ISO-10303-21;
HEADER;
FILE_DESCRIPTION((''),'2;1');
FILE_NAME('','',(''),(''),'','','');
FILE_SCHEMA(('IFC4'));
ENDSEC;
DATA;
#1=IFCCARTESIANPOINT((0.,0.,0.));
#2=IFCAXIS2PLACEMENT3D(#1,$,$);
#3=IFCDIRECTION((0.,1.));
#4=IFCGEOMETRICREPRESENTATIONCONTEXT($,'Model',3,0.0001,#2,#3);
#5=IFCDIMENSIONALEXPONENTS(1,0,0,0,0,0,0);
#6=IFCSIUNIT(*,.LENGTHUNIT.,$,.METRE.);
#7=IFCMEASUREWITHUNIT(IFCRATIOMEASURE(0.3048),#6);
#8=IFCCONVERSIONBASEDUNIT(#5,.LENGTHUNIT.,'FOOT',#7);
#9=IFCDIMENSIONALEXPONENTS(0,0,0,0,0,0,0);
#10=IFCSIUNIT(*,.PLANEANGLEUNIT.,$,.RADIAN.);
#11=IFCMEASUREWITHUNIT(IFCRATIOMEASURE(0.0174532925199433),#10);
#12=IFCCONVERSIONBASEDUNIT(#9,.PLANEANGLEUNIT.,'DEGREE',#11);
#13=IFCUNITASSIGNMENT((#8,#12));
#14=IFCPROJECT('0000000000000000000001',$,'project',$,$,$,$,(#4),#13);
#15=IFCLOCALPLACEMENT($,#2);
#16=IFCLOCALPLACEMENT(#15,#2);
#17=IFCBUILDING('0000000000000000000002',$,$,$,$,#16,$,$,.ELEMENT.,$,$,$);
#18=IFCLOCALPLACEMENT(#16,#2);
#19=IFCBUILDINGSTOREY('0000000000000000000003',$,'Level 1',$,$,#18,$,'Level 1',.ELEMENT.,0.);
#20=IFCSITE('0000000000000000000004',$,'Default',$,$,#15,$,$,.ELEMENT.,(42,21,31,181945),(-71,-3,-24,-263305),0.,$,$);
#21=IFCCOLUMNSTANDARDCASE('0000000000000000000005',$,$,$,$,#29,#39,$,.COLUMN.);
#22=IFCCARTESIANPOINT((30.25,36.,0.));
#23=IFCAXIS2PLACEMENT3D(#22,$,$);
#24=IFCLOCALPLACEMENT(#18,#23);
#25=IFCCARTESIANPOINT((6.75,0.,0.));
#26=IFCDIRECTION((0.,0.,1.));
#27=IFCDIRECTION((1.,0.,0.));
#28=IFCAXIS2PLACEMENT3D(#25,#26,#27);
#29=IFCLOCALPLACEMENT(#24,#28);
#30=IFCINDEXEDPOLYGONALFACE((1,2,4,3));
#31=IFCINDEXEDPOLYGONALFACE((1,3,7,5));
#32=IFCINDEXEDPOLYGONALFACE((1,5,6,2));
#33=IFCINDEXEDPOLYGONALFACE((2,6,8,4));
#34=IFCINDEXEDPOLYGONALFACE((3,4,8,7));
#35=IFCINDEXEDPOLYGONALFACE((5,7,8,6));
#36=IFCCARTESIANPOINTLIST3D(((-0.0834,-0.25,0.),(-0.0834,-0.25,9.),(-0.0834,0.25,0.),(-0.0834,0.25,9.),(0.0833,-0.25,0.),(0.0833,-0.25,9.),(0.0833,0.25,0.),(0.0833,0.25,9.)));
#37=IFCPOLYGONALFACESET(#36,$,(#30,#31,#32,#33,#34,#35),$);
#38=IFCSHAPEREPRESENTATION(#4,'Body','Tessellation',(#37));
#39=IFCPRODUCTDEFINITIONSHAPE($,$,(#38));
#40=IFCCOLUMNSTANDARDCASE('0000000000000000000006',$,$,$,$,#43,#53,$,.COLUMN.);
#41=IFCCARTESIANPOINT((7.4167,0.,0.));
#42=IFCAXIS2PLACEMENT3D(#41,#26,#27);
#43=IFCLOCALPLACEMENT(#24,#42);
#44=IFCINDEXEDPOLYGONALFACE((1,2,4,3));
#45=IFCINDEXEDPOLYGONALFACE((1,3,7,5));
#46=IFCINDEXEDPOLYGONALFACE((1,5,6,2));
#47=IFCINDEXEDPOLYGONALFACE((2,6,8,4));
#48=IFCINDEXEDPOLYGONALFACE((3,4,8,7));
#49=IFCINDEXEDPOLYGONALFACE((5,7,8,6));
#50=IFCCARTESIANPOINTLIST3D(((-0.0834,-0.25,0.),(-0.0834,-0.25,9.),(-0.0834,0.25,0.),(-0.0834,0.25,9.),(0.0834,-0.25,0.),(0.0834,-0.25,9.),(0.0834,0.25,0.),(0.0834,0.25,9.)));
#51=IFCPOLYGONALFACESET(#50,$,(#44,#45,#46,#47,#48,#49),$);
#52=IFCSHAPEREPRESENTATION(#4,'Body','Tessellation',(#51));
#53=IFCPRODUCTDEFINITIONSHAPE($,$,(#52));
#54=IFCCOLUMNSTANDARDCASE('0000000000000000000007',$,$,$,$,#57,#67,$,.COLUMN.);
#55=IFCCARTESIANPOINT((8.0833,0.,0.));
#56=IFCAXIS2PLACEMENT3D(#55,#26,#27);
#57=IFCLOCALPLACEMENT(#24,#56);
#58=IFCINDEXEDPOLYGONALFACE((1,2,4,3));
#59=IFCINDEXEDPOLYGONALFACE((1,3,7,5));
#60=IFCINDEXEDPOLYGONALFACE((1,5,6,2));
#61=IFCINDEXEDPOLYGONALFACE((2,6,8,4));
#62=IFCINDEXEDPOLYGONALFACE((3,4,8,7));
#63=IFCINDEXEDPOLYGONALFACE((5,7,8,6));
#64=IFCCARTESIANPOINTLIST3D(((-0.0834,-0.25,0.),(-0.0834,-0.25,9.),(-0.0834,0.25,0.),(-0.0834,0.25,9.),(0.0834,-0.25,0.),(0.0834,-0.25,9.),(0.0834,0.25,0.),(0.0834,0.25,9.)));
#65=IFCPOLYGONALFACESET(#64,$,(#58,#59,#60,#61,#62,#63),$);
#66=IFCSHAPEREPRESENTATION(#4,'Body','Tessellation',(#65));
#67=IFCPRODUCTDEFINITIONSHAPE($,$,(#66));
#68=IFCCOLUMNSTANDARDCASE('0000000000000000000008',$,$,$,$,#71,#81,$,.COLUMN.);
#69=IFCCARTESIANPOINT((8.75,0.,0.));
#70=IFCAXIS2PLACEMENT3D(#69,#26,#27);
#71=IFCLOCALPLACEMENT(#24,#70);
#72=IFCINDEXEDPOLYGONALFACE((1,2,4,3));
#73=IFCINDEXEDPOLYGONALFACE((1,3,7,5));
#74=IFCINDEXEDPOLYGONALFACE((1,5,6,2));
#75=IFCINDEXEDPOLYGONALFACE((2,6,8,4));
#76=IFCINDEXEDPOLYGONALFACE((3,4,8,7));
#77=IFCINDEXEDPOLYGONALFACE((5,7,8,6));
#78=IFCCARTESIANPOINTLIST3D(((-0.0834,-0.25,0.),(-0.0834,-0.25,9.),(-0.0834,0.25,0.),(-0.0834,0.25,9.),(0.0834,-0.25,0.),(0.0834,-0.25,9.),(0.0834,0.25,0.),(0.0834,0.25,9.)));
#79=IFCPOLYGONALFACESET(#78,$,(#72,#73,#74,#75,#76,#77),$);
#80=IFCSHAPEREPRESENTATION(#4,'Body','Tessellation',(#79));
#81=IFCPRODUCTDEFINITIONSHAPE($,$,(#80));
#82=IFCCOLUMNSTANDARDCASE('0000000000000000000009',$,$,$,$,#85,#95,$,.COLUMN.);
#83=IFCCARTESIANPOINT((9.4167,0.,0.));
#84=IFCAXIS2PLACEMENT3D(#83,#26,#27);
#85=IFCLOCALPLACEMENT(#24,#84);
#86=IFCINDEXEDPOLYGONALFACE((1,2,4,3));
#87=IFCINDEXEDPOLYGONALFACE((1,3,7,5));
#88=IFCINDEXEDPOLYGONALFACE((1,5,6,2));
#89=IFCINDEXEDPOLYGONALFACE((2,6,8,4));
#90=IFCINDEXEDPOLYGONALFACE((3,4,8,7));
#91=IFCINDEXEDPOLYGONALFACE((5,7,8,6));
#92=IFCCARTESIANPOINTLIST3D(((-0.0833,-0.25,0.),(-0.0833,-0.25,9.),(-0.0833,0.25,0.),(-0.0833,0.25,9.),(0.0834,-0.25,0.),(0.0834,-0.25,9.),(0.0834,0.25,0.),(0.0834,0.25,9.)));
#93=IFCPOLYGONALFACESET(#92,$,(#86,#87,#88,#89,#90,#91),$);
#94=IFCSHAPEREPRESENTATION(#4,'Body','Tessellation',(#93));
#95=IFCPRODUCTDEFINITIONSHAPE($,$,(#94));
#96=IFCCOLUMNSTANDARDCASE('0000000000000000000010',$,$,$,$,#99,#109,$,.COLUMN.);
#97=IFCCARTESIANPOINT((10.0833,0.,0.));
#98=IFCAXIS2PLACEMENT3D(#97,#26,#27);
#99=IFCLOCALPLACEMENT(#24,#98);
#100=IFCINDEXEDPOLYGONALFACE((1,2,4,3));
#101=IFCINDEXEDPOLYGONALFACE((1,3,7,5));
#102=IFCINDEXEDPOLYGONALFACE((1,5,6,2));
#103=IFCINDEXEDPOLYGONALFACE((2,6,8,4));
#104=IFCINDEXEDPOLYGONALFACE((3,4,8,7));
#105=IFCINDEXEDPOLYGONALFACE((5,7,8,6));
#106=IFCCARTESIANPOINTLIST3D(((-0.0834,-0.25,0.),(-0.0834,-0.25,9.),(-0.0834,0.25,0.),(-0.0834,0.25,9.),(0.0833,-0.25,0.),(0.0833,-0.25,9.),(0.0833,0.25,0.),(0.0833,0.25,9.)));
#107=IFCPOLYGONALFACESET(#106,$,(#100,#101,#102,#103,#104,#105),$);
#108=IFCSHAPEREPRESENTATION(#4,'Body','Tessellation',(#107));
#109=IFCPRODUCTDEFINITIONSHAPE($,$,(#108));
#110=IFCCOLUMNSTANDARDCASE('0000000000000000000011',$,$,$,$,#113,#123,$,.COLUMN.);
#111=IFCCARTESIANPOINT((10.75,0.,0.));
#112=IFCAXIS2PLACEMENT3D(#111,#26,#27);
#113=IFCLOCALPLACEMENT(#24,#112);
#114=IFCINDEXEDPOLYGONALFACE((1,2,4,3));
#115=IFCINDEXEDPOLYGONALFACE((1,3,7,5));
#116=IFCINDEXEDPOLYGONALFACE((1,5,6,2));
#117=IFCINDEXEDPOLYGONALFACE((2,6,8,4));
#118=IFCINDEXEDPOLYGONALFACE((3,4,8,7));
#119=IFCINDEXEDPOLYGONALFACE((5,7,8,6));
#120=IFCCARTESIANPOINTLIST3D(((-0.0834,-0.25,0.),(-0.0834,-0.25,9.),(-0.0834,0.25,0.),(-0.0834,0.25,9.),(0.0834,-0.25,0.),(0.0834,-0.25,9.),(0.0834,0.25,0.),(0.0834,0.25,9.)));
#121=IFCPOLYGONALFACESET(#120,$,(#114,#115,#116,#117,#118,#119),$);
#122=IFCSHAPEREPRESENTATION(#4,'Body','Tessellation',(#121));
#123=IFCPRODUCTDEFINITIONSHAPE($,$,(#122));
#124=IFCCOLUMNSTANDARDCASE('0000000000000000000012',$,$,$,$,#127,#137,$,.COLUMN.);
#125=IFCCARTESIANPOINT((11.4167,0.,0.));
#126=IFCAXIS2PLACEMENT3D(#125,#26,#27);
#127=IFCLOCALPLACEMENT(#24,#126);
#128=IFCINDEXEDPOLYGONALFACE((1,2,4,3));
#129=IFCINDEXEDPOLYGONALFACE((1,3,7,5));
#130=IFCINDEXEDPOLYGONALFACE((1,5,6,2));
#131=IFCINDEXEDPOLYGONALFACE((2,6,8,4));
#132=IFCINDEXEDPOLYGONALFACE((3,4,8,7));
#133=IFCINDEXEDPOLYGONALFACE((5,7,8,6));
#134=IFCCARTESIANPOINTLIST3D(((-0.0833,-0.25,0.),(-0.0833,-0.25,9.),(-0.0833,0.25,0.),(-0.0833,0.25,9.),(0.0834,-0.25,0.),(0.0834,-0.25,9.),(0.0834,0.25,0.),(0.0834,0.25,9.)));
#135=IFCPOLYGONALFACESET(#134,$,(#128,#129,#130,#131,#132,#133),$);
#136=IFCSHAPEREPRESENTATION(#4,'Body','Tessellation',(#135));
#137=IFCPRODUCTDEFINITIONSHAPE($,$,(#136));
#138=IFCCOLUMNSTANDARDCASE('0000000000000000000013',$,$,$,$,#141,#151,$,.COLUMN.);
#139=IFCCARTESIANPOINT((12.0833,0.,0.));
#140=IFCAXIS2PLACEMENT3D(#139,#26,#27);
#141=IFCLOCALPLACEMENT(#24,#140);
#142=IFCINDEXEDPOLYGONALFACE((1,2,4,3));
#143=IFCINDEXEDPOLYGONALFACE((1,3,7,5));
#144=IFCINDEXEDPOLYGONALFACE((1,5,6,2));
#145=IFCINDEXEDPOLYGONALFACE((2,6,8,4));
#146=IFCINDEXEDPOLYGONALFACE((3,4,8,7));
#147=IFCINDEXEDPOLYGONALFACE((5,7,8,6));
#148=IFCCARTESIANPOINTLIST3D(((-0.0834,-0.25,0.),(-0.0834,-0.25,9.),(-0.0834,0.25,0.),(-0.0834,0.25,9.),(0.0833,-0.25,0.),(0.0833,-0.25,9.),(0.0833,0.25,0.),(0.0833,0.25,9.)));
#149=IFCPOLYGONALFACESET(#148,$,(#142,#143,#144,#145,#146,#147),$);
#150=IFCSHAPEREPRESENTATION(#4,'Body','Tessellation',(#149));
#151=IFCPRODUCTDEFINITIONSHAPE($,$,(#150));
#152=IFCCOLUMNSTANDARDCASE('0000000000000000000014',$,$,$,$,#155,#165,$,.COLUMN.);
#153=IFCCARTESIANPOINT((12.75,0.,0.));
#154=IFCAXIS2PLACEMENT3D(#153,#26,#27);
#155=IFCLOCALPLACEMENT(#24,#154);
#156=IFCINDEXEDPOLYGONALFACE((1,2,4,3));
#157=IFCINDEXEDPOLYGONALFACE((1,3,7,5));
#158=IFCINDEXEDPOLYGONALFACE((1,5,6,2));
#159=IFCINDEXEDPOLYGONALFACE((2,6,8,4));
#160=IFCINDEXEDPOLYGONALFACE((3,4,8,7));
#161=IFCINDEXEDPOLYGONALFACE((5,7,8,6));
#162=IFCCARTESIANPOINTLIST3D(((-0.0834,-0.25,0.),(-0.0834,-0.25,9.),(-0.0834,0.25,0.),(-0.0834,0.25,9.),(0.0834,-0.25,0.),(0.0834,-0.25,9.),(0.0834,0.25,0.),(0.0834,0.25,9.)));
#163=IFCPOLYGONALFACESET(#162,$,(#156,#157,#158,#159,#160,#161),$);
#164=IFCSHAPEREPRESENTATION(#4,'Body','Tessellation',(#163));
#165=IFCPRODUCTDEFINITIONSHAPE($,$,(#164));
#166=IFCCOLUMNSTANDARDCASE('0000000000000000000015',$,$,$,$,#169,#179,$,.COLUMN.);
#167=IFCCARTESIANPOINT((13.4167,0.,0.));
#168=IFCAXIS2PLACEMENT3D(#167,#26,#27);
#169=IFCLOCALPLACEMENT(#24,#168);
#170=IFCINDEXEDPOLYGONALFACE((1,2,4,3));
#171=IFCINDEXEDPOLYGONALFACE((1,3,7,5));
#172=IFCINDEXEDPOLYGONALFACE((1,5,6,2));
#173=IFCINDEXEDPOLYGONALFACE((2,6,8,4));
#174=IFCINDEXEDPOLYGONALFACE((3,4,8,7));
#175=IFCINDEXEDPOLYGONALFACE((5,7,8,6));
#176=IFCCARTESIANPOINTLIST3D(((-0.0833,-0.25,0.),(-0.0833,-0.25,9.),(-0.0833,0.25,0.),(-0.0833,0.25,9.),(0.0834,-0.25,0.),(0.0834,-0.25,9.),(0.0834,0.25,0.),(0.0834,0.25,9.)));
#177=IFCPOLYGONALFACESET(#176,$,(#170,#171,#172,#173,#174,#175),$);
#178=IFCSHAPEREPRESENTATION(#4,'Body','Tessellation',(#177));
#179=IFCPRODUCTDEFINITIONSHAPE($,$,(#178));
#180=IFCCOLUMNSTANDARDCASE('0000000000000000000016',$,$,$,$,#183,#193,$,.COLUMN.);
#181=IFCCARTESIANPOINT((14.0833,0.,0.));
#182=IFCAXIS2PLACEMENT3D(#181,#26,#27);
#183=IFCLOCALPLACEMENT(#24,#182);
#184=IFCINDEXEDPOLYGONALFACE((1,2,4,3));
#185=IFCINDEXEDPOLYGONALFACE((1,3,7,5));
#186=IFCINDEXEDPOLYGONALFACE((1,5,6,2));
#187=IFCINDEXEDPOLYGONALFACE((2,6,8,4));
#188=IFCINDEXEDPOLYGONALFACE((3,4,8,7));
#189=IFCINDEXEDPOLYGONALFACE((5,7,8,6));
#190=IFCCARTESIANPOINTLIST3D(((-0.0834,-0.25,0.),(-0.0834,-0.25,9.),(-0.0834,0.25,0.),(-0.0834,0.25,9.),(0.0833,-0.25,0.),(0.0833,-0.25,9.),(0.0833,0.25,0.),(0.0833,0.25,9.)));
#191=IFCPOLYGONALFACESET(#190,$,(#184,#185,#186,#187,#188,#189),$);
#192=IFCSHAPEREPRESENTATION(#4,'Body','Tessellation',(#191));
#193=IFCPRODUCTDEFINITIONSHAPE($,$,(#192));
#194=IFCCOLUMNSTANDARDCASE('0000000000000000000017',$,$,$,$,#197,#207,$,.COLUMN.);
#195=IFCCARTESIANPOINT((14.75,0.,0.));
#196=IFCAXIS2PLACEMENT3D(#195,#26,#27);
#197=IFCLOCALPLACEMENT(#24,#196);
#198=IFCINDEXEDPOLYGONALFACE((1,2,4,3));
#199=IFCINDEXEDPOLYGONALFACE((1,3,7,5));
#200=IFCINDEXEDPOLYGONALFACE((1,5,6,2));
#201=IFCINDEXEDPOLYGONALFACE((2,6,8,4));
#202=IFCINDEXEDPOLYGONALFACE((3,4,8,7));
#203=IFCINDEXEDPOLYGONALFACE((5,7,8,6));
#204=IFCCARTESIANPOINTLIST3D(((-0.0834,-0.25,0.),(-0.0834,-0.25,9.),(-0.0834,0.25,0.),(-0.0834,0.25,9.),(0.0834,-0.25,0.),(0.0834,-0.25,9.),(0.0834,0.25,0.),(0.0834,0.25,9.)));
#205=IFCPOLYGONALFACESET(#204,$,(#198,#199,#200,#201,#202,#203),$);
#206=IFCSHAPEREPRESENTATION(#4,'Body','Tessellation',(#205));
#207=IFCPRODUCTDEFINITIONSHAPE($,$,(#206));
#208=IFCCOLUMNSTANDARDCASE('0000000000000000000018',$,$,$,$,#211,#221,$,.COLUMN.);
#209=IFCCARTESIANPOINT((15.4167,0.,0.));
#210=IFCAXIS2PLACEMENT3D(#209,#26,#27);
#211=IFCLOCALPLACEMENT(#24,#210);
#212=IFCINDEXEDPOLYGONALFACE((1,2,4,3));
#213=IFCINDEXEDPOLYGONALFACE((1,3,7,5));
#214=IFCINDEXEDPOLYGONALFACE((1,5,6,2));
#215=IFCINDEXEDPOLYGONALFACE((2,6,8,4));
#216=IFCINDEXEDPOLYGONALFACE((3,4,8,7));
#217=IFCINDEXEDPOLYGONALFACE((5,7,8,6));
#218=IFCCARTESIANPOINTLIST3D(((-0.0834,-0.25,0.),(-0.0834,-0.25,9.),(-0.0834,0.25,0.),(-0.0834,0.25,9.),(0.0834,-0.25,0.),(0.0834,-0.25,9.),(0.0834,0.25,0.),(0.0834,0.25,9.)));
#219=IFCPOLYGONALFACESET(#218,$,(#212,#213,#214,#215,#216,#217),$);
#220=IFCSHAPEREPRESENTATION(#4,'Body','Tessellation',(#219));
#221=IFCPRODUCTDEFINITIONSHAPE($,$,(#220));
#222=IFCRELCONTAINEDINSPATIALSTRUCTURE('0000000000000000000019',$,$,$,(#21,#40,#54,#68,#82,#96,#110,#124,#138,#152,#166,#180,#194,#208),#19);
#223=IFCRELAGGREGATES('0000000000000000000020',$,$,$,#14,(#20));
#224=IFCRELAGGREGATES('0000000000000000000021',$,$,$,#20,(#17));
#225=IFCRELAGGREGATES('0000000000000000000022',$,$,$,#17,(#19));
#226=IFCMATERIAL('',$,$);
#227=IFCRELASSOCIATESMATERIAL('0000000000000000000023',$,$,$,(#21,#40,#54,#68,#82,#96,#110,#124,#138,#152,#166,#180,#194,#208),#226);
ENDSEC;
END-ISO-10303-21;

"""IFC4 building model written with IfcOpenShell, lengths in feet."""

from ifc_helpers import new_model, entity, si_unit, converted_unit, direction, frame, origin, place, context, project, spatial, rectangle, extrude, material, element, save


model = new_model("IFC4")

# Units and contexts
model_context = context("Model", 3, precision=0.0001, world=origin(), true_north=direction((0.0, 1.0)))
ifc_project = project(units=[converted_unit("LENGTHUNIT", "FOOT", entity("IfcRatioMeasure", 0.3048), si_unit("LENGTHUNIT", "METRE"), dimensions=[1, 0, 0, 0, 0, 0, 0]), converted_unit("PLANEANGLEUNIT", "DEGREE", entity("IfcRatioMeasure", 0.0174532925199433), si_unit("PLANEANGLEUNIT", "RADIAN"), dimensions=[0, 0, 0, 0, 0, 0, 0])], contexts=[model_context])

# Site, building, storey
site_placement = place(None, origin())
site = spatial("IfcSite", under=ifc_project, at=site_placement, Name="Default", CompositionType="ELEMENT", RefLatitude=(42, 21, 31, 181945), RefLongitude=(-71, -3, -24, -263305), RefElevation=0.0)
building_placement = place(site_placement, origin())
building = spatial("IfcBuilding", under=site, at=building_placement, CompositionType="ELEMENT")
storey_placement = place(building_placement, origin())
storey = spatial("IfcBuildingStorey", under=building, at=storey_placement, Name="Level 1", LongName="Level 1", CompositionType="ELEMENT", Elevation=0.0)

# Columns
ifc_material_1 = material(Name="")
placement_1 = place(storey_placement, frame((30.25, 36.0, 0.0)))
for number, where, z_axis, x_axis in (
    (1, (6.75, 0.0, 0.0), (0.0, 0.0, 1.0), (1.0, 0.0, 0.0)),
    (2, (7.4167, 0.0, 0.0), (0.0, 0.0, 1.0), (1.0, 0.0, 0.0)),
    (3, (8.0833, 0.0, 0.0), (0.0, 0.0, 1.0), (1.0, 0.0, 0.0)),
    (4, (8.75, 0.0, 0.0), (0.0, 0.0, 1.0), (1.0, 0.0, 0.0)),
    (5, (9.4167, 0.0, 0.0), (0.0, 0.0, 1.0), (1.0, 0.0, 0.0)),
    (6, (10.0833, 0.0, 0.0), (0.0, 0.0, 1.0), (1.0, 0.0, 0.0)),
    (7, (10.75, 0.0, 0.0), (0.0, 0.0, 1.0), (1.0, 0.0, 0.0)),
    (8, (11.4167, 0.0, 0.0), (0.0, 0.0, 1.0), (1.0, 0.0, 0.0)),
    (9, (12.0833, 0.0, 0.0), (0.0, 0.0, 1.0), (1.0, 0.0, 0.0)),
    (10, (12.75, 0.0, 0.0), (0.0, 0.0, 1.0), (1.0, 0.0, 0.0)),
    (11, (13.4167, 0.0, 0.0), (0.0, 0.0, 1.0), (1.0, 0.0, 0.0)),
    (12, (14.0833, 0.0, 0.0), (0.0, 0.0, 1.0), (1.0, 0.0, 0.0)),
    (13, (14.75, 0.0, 0.0), (0.0, 0.0, 1.0), (1.0, 0.0, 0.0)),
    (14, (15.4167, 0.0, 0.0), (0.0, 0.0, 1.0), (1.0, 0.0, 0.0)),
):
    element("IfcColumnStandardCase", number, at=place(placement_1, frame(where, z_axis=z_axis, x_axis=x_axis)), inside=storey, material=ifc_material_1, PredefinedType="COLUMN", context=model_context, shape_type="SweptSolid", body=[
        extrude(rectangle(XDim=0.1667, YDim=0.5), origin(), (0.0, 0.0, 1.0), 9.0),
    ])

save(model, "model.ifc")
